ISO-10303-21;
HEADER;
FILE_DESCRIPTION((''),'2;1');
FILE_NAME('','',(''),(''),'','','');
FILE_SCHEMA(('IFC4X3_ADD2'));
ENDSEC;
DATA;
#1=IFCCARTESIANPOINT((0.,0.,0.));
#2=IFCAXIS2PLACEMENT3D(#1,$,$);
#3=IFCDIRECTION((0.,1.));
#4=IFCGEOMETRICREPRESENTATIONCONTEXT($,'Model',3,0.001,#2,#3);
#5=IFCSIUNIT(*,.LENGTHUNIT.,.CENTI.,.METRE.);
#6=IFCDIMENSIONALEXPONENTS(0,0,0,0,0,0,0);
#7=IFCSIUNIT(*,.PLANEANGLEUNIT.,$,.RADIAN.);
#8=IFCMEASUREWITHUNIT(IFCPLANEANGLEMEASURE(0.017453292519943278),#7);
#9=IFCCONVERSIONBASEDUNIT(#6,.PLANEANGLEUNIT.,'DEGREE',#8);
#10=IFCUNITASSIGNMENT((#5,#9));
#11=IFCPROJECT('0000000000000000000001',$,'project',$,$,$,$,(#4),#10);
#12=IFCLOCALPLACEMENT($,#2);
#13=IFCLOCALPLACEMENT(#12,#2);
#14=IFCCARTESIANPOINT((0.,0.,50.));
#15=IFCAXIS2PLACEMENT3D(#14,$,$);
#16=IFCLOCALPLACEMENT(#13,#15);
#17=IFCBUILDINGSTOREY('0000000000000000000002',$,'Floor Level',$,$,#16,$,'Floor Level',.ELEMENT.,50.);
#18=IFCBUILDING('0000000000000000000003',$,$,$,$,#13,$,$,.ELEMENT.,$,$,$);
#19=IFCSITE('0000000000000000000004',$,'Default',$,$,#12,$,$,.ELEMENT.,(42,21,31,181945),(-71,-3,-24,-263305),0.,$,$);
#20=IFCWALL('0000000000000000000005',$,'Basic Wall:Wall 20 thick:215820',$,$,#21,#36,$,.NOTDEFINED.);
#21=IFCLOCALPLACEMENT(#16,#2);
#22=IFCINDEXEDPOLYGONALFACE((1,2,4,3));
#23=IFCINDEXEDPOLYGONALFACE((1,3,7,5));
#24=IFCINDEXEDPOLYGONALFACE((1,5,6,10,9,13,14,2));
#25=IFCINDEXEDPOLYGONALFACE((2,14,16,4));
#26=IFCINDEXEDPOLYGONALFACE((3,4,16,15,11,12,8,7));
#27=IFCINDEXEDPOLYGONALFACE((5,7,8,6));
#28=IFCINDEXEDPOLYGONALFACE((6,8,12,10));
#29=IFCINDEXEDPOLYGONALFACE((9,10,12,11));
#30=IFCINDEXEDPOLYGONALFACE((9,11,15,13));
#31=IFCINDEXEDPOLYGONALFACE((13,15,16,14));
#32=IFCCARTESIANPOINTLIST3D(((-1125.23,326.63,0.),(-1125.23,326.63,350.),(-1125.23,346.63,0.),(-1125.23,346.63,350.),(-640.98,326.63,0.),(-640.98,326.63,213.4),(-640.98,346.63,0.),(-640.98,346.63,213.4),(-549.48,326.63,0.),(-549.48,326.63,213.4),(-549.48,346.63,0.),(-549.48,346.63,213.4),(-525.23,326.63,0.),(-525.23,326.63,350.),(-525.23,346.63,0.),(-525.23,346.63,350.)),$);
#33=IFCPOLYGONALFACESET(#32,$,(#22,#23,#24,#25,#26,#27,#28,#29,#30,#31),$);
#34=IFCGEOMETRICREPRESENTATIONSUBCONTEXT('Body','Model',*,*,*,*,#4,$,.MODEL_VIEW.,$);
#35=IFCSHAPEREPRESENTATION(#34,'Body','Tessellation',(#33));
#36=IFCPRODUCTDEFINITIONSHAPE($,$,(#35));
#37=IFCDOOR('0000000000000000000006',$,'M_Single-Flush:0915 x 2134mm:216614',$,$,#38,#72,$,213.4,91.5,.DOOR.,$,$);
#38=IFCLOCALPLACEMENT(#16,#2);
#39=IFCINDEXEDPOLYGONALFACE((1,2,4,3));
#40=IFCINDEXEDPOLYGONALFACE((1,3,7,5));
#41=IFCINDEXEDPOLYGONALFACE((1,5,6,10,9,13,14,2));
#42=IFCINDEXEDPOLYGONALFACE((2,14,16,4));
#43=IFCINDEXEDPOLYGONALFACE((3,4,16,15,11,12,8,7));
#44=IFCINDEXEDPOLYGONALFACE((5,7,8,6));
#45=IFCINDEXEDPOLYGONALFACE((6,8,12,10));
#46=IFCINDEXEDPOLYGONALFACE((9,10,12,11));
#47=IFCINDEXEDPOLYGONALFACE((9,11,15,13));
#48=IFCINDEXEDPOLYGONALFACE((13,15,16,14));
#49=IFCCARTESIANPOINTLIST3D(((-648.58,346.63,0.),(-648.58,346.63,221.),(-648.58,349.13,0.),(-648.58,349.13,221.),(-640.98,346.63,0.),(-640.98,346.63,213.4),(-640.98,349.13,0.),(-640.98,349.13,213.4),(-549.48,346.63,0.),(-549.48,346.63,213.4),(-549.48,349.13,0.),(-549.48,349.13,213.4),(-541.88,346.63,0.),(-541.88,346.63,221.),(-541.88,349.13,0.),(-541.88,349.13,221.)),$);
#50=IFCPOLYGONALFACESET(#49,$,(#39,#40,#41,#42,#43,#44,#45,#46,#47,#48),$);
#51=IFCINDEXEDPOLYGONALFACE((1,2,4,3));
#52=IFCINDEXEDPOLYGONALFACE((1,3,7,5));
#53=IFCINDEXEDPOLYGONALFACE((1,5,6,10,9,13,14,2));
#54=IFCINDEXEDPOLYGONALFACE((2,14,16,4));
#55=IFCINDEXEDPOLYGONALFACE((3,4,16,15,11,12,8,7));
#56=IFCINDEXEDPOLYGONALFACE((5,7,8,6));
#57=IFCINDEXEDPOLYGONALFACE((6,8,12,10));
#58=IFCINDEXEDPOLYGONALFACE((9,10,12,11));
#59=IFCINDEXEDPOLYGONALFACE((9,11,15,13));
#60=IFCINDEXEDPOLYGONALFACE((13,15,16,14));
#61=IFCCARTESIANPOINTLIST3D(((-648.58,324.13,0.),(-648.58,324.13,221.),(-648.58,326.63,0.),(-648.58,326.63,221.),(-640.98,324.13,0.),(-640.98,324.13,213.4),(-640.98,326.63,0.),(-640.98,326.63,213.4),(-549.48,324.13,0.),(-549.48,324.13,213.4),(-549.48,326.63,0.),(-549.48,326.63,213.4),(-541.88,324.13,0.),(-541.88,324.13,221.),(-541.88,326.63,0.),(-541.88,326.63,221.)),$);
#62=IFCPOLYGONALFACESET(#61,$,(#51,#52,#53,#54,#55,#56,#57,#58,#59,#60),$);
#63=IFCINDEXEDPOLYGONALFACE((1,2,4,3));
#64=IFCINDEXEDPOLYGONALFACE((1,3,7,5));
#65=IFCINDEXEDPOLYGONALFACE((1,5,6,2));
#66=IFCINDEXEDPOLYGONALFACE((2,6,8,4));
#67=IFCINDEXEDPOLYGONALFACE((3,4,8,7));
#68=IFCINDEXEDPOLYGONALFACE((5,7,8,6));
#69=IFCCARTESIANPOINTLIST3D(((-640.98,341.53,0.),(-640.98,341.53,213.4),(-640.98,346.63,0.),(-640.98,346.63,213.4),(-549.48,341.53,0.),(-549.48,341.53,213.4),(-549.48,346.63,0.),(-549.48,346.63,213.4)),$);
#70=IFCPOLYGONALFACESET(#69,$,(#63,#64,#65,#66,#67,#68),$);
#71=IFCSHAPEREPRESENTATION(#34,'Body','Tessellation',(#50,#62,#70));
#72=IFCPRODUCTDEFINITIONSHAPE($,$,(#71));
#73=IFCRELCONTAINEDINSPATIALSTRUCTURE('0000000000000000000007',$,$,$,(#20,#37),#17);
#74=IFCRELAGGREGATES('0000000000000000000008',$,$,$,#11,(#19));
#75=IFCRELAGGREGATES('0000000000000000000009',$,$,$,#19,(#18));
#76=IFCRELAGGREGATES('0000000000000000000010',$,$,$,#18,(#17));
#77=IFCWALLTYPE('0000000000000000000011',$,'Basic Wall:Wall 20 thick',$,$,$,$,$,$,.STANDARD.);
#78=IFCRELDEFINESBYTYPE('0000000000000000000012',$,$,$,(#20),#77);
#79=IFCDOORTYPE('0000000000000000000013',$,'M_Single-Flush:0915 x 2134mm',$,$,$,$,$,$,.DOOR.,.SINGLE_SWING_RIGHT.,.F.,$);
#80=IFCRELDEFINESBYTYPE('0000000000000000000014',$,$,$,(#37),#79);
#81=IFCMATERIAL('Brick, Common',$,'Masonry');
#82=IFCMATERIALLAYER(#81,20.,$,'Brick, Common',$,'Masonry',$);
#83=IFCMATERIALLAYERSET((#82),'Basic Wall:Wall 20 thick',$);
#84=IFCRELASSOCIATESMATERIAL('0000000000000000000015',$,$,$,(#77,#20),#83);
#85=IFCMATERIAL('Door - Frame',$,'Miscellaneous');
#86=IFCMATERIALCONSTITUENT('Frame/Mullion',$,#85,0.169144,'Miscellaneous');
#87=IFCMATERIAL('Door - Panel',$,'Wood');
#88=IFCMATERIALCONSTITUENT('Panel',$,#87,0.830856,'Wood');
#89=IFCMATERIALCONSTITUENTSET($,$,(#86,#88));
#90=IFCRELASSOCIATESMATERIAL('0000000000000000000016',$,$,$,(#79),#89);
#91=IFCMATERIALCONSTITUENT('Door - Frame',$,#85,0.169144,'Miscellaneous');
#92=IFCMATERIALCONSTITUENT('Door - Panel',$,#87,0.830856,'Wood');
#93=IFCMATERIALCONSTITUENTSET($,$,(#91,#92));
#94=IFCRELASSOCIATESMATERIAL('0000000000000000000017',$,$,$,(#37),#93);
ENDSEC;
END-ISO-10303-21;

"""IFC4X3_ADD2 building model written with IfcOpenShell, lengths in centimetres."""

from ifc_helpers import new_model, entity, si_unit, converted_unit, direction, frame, frame_2d, origin, place, context, subcontext, project, spatial, polyline, rectangle, outline, extrude, source, transform, mapped, material, layer, layer_set, constituent, constituent_set, type_object, type_shapes, element, fill, save


model = new_model("IFC4X3_ADD2")

# Units and contexts
model_context = context("Model", 3, precision=0.001, world=origin(), true_north=direction((0.0, 1.0)))
body_context = subcontext(model_context, "Body", "Model", "MODEL_VIEW")
ifc_project = project(units=[si_unit("LENGTHUNIT", "METRE", prefix="CENTI"), converted_unit("PLANEANGLEUNIT", "DEGREE", entity("IfcPlaneAngleMeasure", 0.017453292519943278), si_unit("PLANEANGLEUNIT", "RADIAN"), dimensions=[0, 0, 0, 0, 0, 0, 0])], contexts=[model_context])

# Site, building, storey
site_placement = place(None, origin())
site = spatial("IfcSite", under=ifc_project, at=site_placement, Name="Default", CompositionType="ELEMENT", RefLatitude=(42, 21, 31, 181945), RefLongitude=(-71, -3, -24, -263305), RefElevation=0.0)
building_placement = place(site_placement, origin())
building = spatial("IfcBuilding", under=site, at=building_placement, CompositionType="ELEMENT")
storey_placement = place(building_placement, frame((0.0, 0.0, 50.0)))
storey = spatial("IfcBuildingStorey", under=building, at=storey_placement, Name="Floor Level", LongName="Floor Level", CompositionType="ELEMENT", Elevation=50.0)

# Shared definitions
ifc_material_1 = material(Name="Brick, Common", Category="Masonry")
ifc_layer = layer(ifc_material_1, 20.0, Name="Brick, Common", Category="Masonry")
ifc_layer_set = layer_set([ifc_layer], Name="Basic Wall:Wall 20 thick")
wall_type = type_object("IfcWallType", Name="Basic Wall:Wall 20 thick", PredefinedType="STANDARD", material=ifc_layer_set)

# Shared definitions
ifc_material_2 = material(Name="Door - Frame", Category="Miscellaneous")
ifc_material_3 = material(Name="Door - Panel", Category="Wood")
ifc_constituent_1 = constituent(ifc_material_2, Name="Frame/Mullion", Category="Miscellaneous", fraction=0.169144)
ifc_constituent_2 = constituent(ifc_material_3, Name="Panel", Category="Wood", fraction=0.830856)
ifc_constituent_set_1 = constituent_set(constituents=[ifc_constituent_1, ifc_constituent_2])
door_type = type_object("IfcDoorType", Name="M_Single-Flush:0915 x 2134mm", OperationType="SINGLE_SWING_RIGHT", ParameterTakesPrecedence=False, PredefinedType="DOOR", material=ifc_constituent_set_1)
shared_shape_1 = source(origin(), body_context, "Body", "SweptSolid", [
    extrude(outline(polyline([(-53.35, -112.4), (53.35, -112.4), (53.35, 108.6), (45.75, 108.6), (45.75, -104.8), (-45.75, -104.8), (-45.75, 108.6), (-53.35, 108.6), (-53.35, -112.4)])), frame((45.75, 20.0, 108.6), z_axis=(0.0, 1.0, 0.0), x_axis=(1.0, 0.0, 0.0)), (0.0, 0.0, 1.0), 2.5),
    extrude(outline(polyline([(-112.4, -53.35), (108.6, -53.35), (108.6, -45.75), (-104.8, -45.75), (-104.8, 45.75), (108.6, 45.75), (108.6, 53.35), (-112.4, 53.35), (-112.4, -53.35)])), frame((45.75, -2.5, 108.6), z_axis=(0.0, 1.0, 0.0), x_axis=(0.0, 0.0, -1.0)), (0.0, 0.0, 1.0), 2.5),
    extrude(rectangle(XDim=5.1, YDim=91.5, at=frame_2d((0.0, 0.0), x_axis=(1.0, 0.0))), frame((45.75, 17.45, 0.0), z_axis=(0.0, 0.0, 1.0), x_axis=(0.0, 1.0, 0.0)), (0.0, 0.0, 1.0), 213.4),
])
type_shapes(door_type, [shared_shape_1])

# Wall, opening, door
wall_1_placement = place(storey_placement, frame((-1125.23, 336.63, 0.0)))
wall_1 = element("IfcWall", 1, at=wall_1_placement, inside=storey, type_object=wall_type, material=ifc_layer_set, Name="Basic Wall:Wall 20 thick:215820", PredefinedType="NOTDEFINED", context=body_context, shape_type="SweptSolid", body=[
    extrude(rectangle(XDim=600.0, YDim=20.0, at=frame_2d((300.0, 0.0), x_axis=(-1.0, 0.0))), origin(), (0.0, 0.0, 1.0), 350.0),
])
opening_1_placement = place(wall_1_placement, frame((484.25, -10.0, 0.0)))
opening_1 = element("IfcOpeningElement", 2, at=opening_1_placement, cuts=wall_1, PredefinedType="OPENING", context=body_context, shape_type="SweptSolid", body=[
    extrude(rectangle(XDim=91.5, YDim=213.4, at=frame_2d((106.7, 45.75), x_axis=(0.0, 1.0))), frame((0.0, 0.0, 0.0), z_axis=(0.0, 1.0, 0.0), x_axis=(0.0, 0.0, 1.0)), (0.0, 0.0, 1.0), 20.0),
])
ifc_constituent_3 = constituent(ifc_material_2, Name="Door - Frame", Category="Miscellaneous", fraction=0.169144)
ifc_constituent_4 = constituent(ifc_material_3, Name="Door - Panel", Category="Wood", fraction=0.830856)
ifc_constituent_set_2 = constituent_set(constituents=[ifc_constituent_3, ifc_constituent_4])
door_1_placement = place(opening_1_placement, origin())
door_1 = element("IfcDoor", 3, at=door_1_placement, inside=storey, type_object=door_type, material=ifc_constituent_set_2, Name="M_Single-Flush:0915 x 2134mm:216614", OverallHeight=213.4, OverallWidth=91.5, PredefinedType="DOOR", context=body_context, shape_type="MappedRepresentation", body=[
    mapped(shared_shape_1, transform((0.0, 0.0, 0.0), scale=1.0)),
])
fill(opening_1, door_1)

save(model, "model.ifc")
